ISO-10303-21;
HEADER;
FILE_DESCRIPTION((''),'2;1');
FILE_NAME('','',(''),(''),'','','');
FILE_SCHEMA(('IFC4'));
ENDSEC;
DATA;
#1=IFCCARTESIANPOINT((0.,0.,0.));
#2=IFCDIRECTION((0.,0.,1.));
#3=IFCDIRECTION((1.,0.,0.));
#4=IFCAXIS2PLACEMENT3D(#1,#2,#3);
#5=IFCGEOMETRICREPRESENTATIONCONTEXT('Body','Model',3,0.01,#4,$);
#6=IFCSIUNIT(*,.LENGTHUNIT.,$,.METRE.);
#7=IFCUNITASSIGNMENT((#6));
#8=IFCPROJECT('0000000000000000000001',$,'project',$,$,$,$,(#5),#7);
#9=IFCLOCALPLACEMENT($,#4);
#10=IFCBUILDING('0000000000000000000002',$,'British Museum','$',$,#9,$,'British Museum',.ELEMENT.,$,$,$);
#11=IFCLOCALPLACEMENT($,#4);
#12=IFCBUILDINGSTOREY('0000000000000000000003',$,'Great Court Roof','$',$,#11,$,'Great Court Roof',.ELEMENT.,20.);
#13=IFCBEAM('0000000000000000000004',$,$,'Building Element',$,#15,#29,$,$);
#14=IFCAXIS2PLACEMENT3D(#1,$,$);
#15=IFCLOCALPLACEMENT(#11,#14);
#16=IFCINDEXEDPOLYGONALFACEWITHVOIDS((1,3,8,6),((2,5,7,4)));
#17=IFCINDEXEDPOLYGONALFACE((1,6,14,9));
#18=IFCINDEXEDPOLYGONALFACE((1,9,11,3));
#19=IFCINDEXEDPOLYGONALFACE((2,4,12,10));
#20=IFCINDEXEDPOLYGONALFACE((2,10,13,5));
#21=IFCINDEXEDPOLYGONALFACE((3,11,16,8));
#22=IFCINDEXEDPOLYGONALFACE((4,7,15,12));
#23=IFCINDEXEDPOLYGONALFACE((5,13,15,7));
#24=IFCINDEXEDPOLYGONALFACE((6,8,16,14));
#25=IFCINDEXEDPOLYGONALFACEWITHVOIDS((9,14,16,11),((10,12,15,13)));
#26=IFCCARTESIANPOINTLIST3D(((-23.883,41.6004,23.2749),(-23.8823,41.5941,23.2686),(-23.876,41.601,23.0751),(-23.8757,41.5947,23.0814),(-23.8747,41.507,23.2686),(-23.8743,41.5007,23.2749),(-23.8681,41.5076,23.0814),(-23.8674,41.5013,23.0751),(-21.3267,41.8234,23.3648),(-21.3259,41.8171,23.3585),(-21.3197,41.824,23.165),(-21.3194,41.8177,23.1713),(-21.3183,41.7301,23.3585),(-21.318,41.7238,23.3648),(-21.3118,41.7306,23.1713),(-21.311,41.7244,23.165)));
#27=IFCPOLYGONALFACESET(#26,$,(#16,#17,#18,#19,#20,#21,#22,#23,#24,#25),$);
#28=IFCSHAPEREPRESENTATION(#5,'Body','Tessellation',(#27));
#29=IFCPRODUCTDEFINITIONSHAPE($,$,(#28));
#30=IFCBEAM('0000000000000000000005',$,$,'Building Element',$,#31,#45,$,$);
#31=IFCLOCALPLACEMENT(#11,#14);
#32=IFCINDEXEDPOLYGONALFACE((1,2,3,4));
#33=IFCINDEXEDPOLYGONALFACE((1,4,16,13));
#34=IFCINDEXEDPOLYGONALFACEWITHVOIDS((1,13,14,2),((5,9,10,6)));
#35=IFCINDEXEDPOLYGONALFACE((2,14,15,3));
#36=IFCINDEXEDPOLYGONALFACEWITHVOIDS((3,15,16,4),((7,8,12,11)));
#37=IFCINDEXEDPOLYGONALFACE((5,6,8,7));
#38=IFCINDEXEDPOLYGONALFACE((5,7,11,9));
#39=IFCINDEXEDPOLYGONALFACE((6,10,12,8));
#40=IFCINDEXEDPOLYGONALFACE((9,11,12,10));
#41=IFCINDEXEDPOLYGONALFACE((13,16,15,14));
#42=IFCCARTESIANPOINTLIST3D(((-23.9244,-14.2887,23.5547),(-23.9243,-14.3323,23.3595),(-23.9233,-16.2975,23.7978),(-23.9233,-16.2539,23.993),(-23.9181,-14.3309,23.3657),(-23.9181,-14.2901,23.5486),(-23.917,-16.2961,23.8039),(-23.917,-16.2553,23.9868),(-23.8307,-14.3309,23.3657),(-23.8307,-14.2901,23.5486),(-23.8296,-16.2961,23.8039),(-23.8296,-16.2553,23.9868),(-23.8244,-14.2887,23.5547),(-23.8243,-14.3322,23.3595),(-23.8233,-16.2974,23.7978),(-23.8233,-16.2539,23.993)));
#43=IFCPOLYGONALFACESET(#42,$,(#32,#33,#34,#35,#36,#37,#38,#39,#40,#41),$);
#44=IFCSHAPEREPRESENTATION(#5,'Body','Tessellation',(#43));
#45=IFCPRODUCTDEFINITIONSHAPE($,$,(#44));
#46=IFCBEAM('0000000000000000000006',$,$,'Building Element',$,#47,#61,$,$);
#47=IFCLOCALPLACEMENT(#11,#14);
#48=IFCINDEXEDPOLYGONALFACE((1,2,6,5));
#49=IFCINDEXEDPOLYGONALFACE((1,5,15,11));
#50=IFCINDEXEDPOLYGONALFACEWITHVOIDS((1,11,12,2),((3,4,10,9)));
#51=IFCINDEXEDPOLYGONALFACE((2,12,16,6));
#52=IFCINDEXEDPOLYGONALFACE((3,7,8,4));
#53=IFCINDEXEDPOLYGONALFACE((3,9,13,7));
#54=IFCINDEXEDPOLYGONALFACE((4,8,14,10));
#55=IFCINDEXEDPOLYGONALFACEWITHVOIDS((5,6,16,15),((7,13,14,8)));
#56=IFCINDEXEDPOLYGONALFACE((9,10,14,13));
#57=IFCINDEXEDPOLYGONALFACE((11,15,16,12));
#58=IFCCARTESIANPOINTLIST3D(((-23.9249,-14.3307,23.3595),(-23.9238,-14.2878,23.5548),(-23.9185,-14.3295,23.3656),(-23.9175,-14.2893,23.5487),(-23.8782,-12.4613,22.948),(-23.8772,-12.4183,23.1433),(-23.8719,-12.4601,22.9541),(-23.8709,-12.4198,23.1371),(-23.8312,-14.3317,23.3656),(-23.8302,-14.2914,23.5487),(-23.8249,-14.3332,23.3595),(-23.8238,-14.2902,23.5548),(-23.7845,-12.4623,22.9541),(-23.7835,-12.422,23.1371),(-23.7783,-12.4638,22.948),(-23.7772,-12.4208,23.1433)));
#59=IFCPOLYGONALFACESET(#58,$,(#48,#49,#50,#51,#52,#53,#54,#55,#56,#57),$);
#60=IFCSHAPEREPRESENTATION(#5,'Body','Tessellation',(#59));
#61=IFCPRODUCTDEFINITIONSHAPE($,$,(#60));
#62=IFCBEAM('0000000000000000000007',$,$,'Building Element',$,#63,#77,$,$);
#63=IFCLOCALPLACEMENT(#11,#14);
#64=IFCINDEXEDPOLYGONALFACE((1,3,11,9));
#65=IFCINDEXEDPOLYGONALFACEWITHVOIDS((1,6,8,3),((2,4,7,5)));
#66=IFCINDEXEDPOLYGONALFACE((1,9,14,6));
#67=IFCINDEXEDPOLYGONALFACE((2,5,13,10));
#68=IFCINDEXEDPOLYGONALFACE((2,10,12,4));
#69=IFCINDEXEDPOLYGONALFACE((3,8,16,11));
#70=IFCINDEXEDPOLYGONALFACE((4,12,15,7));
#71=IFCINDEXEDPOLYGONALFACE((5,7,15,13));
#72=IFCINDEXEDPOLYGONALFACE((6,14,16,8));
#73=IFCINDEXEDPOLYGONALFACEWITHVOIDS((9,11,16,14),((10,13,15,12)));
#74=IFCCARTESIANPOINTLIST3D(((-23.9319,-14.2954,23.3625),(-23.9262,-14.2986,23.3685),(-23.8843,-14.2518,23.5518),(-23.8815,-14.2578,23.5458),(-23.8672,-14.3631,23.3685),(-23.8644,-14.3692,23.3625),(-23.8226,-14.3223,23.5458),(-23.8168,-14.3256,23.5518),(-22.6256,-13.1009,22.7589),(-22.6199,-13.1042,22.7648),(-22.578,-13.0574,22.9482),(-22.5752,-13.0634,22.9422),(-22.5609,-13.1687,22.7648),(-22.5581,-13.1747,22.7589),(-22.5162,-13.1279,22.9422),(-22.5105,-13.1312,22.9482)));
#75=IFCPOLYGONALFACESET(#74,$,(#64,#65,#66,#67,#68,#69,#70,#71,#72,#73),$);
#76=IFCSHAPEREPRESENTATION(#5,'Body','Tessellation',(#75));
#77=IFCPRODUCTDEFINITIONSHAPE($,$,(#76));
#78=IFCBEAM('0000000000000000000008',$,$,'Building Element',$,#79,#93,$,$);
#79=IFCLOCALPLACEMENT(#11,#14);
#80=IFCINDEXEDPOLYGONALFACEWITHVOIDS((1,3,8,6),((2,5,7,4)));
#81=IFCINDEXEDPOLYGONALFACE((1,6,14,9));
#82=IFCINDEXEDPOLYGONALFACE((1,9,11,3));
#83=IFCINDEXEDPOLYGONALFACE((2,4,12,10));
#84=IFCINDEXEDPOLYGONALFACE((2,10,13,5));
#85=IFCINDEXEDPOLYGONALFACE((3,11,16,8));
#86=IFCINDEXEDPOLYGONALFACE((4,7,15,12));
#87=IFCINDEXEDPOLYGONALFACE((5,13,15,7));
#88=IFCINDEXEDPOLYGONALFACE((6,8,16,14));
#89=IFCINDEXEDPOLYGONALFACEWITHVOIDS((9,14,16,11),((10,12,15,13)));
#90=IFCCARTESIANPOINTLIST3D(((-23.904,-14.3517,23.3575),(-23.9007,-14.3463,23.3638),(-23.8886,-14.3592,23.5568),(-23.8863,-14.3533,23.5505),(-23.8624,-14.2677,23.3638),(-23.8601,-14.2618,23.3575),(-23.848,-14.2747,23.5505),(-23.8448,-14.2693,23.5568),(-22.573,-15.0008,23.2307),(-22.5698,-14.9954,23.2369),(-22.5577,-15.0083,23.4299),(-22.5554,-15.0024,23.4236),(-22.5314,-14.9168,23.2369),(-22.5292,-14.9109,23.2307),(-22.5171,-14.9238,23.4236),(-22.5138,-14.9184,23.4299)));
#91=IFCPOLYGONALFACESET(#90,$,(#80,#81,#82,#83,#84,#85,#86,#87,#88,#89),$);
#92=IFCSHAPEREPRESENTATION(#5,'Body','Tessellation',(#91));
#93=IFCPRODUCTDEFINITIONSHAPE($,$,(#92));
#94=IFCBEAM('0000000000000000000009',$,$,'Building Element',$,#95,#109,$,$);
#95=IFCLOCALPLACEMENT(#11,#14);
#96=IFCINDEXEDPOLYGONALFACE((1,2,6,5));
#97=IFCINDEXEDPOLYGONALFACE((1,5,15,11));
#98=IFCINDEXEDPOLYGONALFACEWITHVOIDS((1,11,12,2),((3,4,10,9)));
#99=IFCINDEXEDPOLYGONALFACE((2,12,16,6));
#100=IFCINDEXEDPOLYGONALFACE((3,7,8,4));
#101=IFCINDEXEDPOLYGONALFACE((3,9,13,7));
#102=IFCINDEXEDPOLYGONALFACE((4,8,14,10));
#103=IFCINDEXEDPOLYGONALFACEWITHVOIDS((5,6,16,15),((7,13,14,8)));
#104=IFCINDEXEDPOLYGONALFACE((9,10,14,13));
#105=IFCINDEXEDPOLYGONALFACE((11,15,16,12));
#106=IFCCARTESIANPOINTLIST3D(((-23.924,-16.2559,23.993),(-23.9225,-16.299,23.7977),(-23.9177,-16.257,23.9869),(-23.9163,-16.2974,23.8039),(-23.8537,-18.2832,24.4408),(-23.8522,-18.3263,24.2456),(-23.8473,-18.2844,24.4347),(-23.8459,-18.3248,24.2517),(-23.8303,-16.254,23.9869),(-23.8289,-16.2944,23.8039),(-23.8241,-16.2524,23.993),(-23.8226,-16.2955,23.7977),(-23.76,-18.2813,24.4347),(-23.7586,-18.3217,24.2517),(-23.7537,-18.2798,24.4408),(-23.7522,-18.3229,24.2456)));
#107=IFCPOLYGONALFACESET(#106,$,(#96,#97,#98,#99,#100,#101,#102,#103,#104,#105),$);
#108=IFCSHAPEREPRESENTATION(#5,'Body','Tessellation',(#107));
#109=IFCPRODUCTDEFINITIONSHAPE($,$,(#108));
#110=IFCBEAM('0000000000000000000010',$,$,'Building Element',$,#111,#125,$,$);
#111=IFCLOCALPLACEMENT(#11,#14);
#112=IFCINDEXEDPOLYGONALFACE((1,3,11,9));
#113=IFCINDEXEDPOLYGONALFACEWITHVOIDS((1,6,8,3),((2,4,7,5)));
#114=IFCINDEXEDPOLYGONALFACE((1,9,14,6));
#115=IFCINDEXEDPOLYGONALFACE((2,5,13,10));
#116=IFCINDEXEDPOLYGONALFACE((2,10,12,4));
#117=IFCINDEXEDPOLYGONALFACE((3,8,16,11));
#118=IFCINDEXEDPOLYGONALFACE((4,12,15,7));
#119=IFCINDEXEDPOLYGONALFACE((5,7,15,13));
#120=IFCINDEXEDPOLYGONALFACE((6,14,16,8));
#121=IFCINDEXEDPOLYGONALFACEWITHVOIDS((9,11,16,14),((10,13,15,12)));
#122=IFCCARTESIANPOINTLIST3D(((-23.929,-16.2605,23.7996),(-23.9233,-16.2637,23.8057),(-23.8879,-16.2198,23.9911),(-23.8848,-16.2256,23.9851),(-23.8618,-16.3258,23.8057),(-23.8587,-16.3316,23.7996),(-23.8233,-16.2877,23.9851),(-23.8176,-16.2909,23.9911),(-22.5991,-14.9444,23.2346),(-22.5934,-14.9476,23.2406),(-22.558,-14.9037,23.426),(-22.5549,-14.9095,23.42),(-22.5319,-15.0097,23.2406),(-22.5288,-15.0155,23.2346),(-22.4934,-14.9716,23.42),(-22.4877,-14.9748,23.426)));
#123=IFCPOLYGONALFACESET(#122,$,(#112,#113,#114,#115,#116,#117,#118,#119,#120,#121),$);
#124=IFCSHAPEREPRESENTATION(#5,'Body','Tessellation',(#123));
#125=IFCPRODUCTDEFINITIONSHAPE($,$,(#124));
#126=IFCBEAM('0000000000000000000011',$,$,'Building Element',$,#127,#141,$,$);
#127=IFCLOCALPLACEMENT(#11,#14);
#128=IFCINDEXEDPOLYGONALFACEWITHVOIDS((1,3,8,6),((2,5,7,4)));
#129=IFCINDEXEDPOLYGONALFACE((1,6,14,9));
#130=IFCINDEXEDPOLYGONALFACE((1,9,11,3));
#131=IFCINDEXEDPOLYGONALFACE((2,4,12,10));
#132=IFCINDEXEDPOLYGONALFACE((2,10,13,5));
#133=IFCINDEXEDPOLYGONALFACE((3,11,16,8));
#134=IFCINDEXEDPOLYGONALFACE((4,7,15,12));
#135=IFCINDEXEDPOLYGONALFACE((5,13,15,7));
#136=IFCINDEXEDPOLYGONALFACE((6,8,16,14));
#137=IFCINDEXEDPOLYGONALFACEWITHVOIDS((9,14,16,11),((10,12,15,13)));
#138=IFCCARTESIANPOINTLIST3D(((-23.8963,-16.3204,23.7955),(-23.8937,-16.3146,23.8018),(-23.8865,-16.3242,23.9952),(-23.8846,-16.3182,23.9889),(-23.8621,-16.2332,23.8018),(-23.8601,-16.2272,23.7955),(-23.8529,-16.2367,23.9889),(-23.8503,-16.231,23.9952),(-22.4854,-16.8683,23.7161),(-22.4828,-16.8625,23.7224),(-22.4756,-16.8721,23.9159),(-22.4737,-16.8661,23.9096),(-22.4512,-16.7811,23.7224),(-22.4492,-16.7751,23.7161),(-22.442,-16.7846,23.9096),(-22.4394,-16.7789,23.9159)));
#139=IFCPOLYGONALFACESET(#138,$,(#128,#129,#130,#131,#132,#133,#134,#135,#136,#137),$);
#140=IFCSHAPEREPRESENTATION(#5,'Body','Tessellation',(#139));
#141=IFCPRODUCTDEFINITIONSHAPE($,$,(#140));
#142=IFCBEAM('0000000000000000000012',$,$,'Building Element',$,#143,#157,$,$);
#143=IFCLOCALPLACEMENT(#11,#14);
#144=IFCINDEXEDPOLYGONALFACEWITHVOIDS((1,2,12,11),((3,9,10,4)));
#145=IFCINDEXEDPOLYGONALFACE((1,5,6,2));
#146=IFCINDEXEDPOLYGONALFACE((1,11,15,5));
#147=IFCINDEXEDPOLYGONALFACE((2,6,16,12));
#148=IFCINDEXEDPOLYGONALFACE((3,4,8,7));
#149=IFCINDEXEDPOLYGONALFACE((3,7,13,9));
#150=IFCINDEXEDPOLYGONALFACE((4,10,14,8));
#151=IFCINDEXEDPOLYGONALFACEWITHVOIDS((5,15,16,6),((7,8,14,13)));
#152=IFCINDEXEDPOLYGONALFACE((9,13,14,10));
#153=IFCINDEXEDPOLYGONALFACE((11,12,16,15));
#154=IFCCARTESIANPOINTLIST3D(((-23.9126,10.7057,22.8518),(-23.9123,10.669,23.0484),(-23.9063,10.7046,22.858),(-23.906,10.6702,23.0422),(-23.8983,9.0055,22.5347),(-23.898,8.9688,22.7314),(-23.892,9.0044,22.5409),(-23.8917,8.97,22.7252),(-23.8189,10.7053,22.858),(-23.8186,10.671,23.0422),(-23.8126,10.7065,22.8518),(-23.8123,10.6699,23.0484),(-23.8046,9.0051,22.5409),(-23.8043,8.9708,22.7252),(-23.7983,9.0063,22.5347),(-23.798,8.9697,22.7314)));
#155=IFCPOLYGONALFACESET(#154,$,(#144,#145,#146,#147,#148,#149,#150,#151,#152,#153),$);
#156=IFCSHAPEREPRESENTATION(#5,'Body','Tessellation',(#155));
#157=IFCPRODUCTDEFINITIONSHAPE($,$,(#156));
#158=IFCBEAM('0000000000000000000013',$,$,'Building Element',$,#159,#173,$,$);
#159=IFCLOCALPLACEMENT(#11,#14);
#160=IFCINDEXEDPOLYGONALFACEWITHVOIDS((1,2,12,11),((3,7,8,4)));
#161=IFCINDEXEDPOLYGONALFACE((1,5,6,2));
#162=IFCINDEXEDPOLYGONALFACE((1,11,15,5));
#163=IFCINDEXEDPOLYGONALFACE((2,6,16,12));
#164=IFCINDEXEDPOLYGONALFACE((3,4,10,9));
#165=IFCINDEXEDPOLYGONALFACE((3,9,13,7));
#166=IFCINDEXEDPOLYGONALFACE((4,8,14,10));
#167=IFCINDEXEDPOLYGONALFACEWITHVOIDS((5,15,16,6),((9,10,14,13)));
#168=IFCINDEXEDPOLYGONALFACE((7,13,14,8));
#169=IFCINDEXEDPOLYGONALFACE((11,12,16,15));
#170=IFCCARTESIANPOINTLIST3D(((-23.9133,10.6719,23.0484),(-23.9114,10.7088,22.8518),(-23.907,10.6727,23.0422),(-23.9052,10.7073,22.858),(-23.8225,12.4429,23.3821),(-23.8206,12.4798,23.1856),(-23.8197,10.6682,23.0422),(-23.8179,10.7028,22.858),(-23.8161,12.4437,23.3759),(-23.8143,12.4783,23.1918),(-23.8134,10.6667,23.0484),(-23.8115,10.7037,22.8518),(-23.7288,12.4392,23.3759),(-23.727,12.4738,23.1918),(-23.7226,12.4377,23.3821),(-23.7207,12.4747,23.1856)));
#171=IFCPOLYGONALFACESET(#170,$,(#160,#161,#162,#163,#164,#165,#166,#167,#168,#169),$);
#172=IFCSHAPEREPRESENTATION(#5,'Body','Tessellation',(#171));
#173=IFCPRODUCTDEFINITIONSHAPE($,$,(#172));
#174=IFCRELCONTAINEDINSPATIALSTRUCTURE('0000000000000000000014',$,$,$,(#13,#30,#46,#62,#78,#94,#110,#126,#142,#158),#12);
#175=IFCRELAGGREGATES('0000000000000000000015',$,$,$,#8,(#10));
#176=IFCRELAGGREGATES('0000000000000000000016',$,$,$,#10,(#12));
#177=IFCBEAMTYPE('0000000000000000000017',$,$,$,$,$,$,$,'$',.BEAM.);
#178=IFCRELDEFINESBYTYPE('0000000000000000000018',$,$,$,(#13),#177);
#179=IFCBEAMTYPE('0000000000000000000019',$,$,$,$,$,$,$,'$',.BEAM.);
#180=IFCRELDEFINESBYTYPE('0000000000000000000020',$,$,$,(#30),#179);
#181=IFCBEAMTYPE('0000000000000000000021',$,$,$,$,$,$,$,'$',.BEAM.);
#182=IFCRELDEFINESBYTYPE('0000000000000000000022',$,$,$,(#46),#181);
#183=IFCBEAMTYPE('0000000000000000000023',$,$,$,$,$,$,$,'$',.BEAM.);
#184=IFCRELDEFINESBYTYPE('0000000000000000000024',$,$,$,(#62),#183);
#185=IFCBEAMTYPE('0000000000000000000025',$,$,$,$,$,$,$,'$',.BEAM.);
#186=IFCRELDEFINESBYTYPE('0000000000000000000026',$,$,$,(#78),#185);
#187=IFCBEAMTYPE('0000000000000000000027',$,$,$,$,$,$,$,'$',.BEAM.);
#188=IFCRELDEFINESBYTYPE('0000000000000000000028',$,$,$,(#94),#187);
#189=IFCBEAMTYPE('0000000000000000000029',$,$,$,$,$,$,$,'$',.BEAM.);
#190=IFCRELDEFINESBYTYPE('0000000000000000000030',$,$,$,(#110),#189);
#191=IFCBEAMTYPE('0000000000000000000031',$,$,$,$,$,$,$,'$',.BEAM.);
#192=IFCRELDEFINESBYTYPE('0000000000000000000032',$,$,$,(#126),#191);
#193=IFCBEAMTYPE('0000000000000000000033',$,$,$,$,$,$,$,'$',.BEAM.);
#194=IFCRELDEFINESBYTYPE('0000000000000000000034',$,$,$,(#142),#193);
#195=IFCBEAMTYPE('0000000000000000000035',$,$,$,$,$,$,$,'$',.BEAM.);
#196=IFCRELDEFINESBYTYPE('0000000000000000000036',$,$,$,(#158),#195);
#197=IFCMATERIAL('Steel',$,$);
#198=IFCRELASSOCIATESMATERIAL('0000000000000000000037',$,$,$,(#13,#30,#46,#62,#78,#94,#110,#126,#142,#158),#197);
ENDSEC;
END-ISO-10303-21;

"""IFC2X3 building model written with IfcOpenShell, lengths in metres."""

from ifc_helpers import new_model, si_unit, frame, origin_with_axes, origin_2d, place, context, project, spatial, hollow_rectangle, extrude, material, type_object, element, save


model = new_model("IFC2X3")

# Units and contexts
model_context = context("Model", 3, precision=0.01, world=origin_with_axes(), identifier="Body")
ifc_project = project(units=[si_unit("LENGTHUNIT", "METRE")], contexts=[model_context])

# Building, storey
building_placement = place(None, origin_with_axes())
building = spatial("IfcBuilding", under=ifc_project, at=building_placement, Name="British Museum", Description="$", LongName="British Museum", CompositionType="ELEMENT")
storey_placement = place(None, origin_with_axes())
storey = spatial("IfcBuildingStorey", under=building, at=storey_placement, Name="Great Court Roof", Description="$", LongName="Great Court Roof", CompositionType="ELEMENT", Elevation=20.0)

# Beams
ifc_material = material(Name="Steel")
beam_type_1 = type_object("IfcBeamType", ElementType="$", PredefinedType="BEAM")
beam_1_placement = place(None, origin_with_axes())
element("IfcBeam", 1, at=beam_1_placement, inside=storey, type_object=beam_type_1, material=ifc_material, Description="Building Element", context=model_context, shape_type="SweptSolid", body=[
    extrude(hollow_rectangle(XDim=0.1, YDim=0.2, WallThickness=0.0063, InnerFilletRadius=-0.0063, OuterFilletRadius=0.0, at=origin_2d()), frame((-23.8752, 41.5509, 23.175), z_axis=(0.995605, 0.086862, 0.035013), x_axis=(-0.086916, 0.996216, 0.0)), (0.0, 0.0, 1.0), 2.5676),
])
beam_type_2 = type_object("IfcBeamType", ElementType="$", PredefinedType="BEAM")
beam_2_placement = place(None, origin_with_axes())
element("IfcBeam", 2, at=beam_2_placement, inside=storey, type_object=beam_type_2, material=ifc_material, Description="Building Element", context=model_context, shape_type="SweptSolid", body=[
    extrude(hollow_rectangle(XDim=0.1, YDim=0.2, WallThickness=0.0063, InnerFilletRadius=-0.0063, OuterFilletRadius=0.0, at=origin_2d()), frame((-23.8744, -14.3105, 23.4571), z_axis=(0.000524, -0.976028, 0.217646), x_axis=(1.0, 0.000537, 0.0)), (0.0, 0.0, 1.0), 2.0135),
])
beam_type_3 = type_object("IfcBeamType", ElementType="$", PredefinedType="BEAM")
beam_3_placement = place(None, origin_with_axes())
element("IfcBeam", 3, at=beam_3_placement, inside=storey, type_object=beam_type_3, material=ifc_material, Description="Building Element", context=model_context, shape_type="SweptSolid", body=[
    extrude(hollow_rectangle(XDim=0.1, YDim=0.2, WallThickness=0.0063, InnerFilletRadius=-0.0063, OuterFilletRadius=0.0, at=origin_2d()), frame((-23.8744, -14.3105, 23.4571), z_axis=(0.024363, 0.976328, -0.214918), x_axis=(-0.999689, 0.024946, 0.0)), (0.0, 0.0, 1.0), 1.9148),
])
beam_type_4 = type_object("IfcBeamType", ElementType="$", PredefinedType="BEAM")
beam_4_placement = place(None, origin_with_axes())
element("IfcBeam", 4, at=beam_4_placement, inside=storey, type_object=beam_type_4, material=ifc_material, Description="Building Element", context=model_context, shape_type="SweptSolid", body=[
    extrude(hollow_rectangle(XDim=0.1, YDim=0.2, WallThickness=0.0063, InnerFilletRadius=-0.0063, OuterFilletRadius=0.0, at=origin_2d()), frame((-23.8744, -14.3105, 23.4571), z_axis=(0.698502, 0.638684, -0.322766), x_axis=(-0.6748, 0.738001, 0.0)), (0.0, 0.0, 1.0), 1.8702),
])
beam_type_5 = type_object("IfcBeamType", ElementType="$", PredefinedType="BEAM")
beam_5_placement = place(None, origin_with_axes())
element("IfcBeam", 5, at=beam_5_placement, inside=storey, type_object=beam_type_5, material=ifc_material, Description="Building Element", context=model_context, shape_type="SweptSolid", body=[
    extrude(hollow_rectangle(XDim=0.1, YDim=0.2, WallThickness=0.0063, InnerFilletRadius=-0.0063, OuterFilletRadius=0.0, at=origin_2d()), frame((-23.8744, -14.3105, 23.4571), z_axis=(0.895518, -0.436763, -0.085351), x_axis=(0.438363, 0.898798, 0.0)), (0.0, 0.0, 1.0), 1.4862),
])
beam_type_6 = type_object("IfcBeamType", ElementType="$", PredefinedType="BEAM")
beam_6_placement = place(None, origin_with_axes())
element("IfcBeam", 6, at=beam_6_placement, inside=storey, type_object=beam_type_6, material=ifc_material, Description="Building Element", context=model_context, shape_type="SweptSolid", body=[
    extrude(hollow_rectangle(XDim=0.1, YDim=0.2, WallThickness=0.0063, InnerFilletRadius=-0.0063, OuterFilletRadius=0.0, at=origin_2d()), frame((-23.8733, -16.2757, 23.8954), z_axis=(0.033874, -0.9759, 0.215572), x_axis=(0.999398, 0.03469, 0.0)), (0.0, 0.0, 1.0), 2.0774),
])
beam_type_7 = type_object("IfcBeamType", ElementType="$", PredefinedType="BEAM")
beam_7_placement = place(None, origin_with_axes())
element("IfcBeam", 7, at=beam_7_placement, inside=storey, type_object=beam_type_7, material=ifc_material, Description="Building Element", context=model_context, shape_type="SweptSolid", body=[
    extrude(hollow_rectangle(XDim=0.1, YDim=0.2, WallThickness=0.0063, InnerFilletRadius=-0.0063, OuterFilletRadius=0.0, at=origin_2d()), frame((-23.8733, -16.2757, 23.8954), z_axis=(0.680437, 0.673362, -0.289119), x_axis=(-0.703402, 0.710792, 0.0)), (0.0, 0.0, 1.0), 1.9545),
])
beam_type_8 = type_object("IfcBeamType", ElementType="$", PredefinedType="BEAM")
beam_8_placement = place(None, origin_with_axes())
element("IfcBeam", 8, at=beam_8_placement, inside=storey, type_object=beam_type_8, material=ifc_material, Description="Building Element", context=model_context, shape_type="SweptSolid", body=[
    extrude(hollow_rectangle(XDim=0.1, YDim=0.2, WallThickness=0.0063, InnerFilletRadius=-0.0063, OuterFilletRadius=0.0, at=origin_2d()), frame((-23.8733, -16.2757, 23.8954), z_axis=(0.930901, -0.361498, -0.052363), x_axis=(0.361994, 0.93218, 0.0)), (0.0, 0.0, 1.0), 1.5156),
])
beam_type_9 = type_object("IfcBeamType", ElementType="$", PredefinedType="BEAM")
beam_9_placement = place(None, origin_with_axes())
element("IfcBeam", 9, at=beam_9_placement, inside=storey, type_object=beam_type_9, material=ifc_material, Description="Building Element", context=model_context, shape_type="SweptSolid", body=[
    extrude(hollow_rectangle(XDim=0.1, YDim=0.2, WallThickness=0.0063, InnerFilletRadius=-0.0063, OuterFilletRadius=0.0, at=origin_2d()), frame((-23.8624, 10.6878, 22.9501), z_axis=(0.008257, -0.983018, -0.183324), x_axis=(0.999965, 0.008399, 0.0)), (0.0, 0.0, 1.0), 1.7296),
])
beam_type_10 = type_object("IfcBeamType", ElementType="$", PredefinedType="BEAM")
beam_10_placement = place(None, origin_with_axes())
element("IfcBeam", 10, at=beam_10_placement, inside=storey, type_object=beam_type_10, material=ifc_material, Description="Building Element", context=model_context, shape_type="SweptSolid", body=[
    extrude(hollow_rectangle(XDim=0.1, YDim=0.2, WallThickness=0.0063, InnerFilletRadius=-0.0063, OuterFilletRadius=0.0, at=origin_2d()), frame((-23.8624, 10.6878, 22.9501), z_axis=(0.050353, 0.981459, 0.184941), x_axis=(-0.998687, 0.051237, 0.0)), (0.0, 0.0, 1.0), 1.8045),
])

save(model, "model.ifc")
